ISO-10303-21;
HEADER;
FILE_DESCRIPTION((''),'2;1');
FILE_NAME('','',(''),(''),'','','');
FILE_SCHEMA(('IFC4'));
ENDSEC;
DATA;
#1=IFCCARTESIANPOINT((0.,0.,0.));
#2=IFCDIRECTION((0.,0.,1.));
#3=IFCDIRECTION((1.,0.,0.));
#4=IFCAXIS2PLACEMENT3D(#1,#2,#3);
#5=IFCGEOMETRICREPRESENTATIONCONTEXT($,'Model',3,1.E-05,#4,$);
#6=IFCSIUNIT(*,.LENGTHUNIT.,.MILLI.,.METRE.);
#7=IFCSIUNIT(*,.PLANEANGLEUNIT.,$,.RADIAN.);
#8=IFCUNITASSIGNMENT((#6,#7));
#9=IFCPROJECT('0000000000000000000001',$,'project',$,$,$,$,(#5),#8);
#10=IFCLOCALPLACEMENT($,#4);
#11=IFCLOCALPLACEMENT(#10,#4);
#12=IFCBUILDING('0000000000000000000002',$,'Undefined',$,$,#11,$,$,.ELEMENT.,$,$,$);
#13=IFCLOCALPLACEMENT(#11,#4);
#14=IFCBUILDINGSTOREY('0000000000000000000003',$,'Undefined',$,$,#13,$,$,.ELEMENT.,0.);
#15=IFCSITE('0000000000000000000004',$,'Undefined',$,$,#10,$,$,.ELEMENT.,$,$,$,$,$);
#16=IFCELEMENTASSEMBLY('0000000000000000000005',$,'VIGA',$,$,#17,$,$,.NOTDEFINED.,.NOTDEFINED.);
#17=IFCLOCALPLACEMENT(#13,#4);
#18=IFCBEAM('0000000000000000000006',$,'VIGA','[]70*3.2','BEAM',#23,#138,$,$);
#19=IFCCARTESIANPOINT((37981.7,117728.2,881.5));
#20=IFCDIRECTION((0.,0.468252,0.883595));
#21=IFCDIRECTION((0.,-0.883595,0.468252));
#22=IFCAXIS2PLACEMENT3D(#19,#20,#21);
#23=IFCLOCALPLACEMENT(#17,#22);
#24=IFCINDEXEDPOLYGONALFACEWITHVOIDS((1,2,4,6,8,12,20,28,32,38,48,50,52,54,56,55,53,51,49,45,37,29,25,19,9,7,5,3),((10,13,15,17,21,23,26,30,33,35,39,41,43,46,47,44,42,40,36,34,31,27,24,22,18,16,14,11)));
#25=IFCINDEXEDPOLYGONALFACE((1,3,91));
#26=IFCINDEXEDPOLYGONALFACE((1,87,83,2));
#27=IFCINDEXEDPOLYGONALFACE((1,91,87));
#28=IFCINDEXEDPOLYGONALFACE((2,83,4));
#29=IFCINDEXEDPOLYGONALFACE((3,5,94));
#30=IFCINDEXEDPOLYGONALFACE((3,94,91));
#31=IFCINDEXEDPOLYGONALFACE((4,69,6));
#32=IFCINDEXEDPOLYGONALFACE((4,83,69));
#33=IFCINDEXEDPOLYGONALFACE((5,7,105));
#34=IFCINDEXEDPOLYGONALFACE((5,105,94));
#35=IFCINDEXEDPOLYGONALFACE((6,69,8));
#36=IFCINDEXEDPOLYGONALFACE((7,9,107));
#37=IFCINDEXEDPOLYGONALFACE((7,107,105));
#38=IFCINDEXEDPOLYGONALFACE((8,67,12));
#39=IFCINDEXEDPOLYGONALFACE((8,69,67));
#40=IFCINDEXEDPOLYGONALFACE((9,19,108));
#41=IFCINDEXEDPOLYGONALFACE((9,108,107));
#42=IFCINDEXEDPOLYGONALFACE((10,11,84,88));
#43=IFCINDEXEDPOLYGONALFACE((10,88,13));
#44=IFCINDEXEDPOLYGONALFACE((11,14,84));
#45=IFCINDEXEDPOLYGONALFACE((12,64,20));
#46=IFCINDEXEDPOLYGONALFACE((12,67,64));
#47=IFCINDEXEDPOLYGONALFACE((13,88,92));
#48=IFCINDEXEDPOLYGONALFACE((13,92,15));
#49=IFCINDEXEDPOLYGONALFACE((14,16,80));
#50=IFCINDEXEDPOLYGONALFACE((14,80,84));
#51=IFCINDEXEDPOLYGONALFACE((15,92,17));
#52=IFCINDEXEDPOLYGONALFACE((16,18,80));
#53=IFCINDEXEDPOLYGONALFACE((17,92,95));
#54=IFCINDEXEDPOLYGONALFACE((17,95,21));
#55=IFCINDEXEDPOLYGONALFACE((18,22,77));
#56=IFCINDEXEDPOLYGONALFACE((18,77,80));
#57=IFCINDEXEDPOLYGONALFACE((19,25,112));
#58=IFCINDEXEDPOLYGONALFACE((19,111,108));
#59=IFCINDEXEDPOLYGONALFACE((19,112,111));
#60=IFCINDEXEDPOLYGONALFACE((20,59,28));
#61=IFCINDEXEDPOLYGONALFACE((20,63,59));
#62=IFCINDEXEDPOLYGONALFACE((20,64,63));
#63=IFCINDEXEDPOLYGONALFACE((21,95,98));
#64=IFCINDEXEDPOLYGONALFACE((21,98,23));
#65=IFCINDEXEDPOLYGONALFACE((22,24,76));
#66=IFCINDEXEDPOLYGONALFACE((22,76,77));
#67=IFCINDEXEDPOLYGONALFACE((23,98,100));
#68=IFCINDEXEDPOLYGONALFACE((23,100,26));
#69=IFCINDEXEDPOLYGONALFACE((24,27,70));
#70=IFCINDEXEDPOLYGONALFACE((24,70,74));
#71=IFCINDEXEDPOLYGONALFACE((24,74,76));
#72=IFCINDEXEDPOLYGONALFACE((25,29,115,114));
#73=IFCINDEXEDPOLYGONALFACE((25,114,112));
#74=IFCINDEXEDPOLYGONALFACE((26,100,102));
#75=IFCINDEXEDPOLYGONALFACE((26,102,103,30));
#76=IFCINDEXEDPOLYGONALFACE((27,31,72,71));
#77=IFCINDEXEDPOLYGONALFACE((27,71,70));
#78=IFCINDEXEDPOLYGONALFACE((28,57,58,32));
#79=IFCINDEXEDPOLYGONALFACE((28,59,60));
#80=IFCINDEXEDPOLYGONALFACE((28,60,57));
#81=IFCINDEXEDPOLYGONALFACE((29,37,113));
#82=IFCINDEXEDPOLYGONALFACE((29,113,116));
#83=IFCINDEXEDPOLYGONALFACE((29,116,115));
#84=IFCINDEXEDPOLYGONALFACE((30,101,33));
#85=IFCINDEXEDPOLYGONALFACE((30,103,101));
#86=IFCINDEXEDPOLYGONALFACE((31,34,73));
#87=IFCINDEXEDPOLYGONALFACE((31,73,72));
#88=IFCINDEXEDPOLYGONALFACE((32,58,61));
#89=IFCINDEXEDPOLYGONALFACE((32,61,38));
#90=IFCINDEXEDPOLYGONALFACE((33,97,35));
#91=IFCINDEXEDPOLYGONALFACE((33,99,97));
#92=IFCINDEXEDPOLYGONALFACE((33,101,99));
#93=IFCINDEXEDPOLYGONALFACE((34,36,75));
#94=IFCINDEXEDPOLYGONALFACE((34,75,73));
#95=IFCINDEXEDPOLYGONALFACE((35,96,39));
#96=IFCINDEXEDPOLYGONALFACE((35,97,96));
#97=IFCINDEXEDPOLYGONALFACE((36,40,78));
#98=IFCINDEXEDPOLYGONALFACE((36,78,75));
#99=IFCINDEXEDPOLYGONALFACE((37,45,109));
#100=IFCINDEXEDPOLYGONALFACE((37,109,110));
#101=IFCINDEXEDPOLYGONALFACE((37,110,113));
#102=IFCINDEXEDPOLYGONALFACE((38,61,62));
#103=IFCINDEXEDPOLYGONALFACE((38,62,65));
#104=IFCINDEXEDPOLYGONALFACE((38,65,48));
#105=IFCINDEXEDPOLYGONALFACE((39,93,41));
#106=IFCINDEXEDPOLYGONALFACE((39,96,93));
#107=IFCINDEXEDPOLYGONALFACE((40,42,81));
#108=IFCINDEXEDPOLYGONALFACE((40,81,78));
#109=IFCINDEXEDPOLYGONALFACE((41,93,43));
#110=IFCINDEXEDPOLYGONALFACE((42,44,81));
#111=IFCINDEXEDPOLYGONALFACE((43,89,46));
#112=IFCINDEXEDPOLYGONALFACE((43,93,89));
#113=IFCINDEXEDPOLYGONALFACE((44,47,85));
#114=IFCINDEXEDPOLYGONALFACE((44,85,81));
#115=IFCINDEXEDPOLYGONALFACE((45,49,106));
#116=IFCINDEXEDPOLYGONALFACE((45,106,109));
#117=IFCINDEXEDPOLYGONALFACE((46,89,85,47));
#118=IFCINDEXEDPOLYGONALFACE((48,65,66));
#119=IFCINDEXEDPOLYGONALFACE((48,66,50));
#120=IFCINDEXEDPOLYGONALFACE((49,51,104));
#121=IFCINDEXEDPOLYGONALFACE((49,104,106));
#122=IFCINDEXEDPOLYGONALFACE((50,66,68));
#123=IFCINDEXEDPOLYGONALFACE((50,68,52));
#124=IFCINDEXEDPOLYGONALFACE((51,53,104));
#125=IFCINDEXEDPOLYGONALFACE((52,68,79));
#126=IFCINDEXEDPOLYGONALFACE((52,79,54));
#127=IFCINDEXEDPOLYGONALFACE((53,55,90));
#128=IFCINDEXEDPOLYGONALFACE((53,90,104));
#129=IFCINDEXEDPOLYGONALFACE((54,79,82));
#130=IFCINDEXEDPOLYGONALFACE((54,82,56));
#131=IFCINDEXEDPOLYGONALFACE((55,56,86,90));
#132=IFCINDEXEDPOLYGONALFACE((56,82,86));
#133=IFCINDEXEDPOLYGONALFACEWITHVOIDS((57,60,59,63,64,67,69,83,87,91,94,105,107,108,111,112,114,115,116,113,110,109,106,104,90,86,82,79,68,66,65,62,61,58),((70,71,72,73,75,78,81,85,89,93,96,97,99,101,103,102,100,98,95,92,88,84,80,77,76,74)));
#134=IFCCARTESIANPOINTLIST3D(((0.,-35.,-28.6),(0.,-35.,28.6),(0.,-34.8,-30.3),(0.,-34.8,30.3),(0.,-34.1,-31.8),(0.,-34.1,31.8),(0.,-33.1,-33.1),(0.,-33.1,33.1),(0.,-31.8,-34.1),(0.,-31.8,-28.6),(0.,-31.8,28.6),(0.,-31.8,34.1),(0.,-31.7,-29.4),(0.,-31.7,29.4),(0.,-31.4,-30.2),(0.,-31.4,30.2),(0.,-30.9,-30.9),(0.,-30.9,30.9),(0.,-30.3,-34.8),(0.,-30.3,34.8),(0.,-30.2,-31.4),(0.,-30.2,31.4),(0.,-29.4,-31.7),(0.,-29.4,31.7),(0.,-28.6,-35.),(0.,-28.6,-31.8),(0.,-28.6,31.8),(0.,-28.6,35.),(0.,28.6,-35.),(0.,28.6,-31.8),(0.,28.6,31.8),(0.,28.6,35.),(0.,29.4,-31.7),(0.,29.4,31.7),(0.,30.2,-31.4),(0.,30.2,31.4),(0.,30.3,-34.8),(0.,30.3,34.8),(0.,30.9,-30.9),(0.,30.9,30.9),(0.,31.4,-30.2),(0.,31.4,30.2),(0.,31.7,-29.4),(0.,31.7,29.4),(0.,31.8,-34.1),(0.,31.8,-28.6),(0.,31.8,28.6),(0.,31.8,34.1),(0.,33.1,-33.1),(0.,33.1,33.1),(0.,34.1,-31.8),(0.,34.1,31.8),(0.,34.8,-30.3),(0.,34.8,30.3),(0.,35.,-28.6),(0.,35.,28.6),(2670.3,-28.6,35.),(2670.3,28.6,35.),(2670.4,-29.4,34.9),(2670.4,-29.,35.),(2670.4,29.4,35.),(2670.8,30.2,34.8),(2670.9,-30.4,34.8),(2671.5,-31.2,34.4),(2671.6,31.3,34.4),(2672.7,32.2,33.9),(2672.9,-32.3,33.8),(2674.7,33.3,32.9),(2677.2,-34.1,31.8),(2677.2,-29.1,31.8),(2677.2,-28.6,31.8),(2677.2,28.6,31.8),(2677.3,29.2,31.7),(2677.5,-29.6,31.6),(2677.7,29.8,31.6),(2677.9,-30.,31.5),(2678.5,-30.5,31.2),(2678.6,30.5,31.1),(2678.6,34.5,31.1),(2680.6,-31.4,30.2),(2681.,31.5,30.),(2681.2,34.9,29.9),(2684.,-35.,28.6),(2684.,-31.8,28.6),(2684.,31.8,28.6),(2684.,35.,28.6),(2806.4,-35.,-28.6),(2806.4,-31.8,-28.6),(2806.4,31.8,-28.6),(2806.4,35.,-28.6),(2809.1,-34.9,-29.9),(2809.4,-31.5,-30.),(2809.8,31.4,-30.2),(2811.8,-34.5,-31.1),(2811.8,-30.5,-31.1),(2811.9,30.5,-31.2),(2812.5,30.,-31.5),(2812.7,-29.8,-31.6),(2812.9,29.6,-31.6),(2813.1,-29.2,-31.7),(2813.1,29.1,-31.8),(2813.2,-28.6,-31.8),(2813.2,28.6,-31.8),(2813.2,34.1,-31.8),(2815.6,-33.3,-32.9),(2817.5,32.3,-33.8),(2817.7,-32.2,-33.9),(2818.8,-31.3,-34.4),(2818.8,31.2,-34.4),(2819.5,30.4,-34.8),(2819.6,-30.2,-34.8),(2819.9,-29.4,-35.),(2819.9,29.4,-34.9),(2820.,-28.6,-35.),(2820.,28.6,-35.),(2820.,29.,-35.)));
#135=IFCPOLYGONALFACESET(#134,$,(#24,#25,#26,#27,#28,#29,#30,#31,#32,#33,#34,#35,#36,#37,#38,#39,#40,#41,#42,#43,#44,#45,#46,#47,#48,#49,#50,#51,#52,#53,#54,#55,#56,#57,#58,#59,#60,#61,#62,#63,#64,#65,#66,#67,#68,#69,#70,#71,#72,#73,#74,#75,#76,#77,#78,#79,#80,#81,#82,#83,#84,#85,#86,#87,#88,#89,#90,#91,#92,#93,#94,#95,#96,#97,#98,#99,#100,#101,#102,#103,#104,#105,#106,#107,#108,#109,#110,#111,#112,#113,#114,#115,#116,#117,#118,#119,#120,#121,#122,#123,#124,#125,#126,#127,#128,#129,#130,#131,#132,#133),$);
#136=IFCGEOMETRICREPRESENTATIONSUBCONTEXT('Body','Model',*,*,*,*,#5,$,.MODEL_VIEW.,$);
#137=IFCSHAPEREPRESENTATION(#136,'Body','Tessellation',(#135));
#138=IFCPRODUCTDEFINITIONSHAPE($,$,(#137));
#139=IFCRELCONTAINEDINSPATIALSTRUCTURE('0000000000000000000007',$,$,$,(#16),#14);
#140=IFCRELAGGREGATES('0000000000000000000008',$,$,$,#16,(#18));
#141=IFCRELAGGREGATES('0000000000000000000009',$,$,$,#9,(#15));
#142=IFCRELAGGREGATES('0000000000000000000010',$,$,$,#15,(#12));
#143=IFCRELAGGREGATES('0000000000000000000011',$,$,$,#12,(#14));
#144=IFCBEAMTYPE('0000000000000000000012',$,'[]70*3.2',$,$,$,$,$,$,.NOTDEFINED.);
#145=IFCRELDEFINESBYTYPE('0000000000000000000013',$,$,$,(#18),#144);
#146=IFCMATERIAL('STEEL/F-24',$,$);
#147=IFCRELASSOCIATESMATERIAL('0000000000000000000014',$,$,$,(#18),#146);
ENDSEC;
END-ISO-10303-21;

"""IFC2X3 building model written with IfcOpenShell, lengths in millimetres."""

from ifc_helpers import new_model, si_unit, frame, origin_with_axes, origin_2d_with_axis, place, context, subcontext, project, spatial, hollow_rectangle, extrude, clip, halfspace, material, type_object, element, aggregate, save


model = new_model("IFC2X3")

# Units and contexts
model_context = context("Model", 3, precision=1e-05, world=origin_with_axes())
body_context = subcontext(model_context, "Body", "Model", "MODEL_VIEW")
ifc_project = project(units=[si_unit("LENGTHUNIT", "METRE", prefix="MILLI"), si_unit("PLANEANGLEUNIT", "RADIAN")], contexts=[model_context])

# Site, building, storey
site_placement = place(None, origin_with_axes())
site = spatial("IfcSite", under=ifc_project, at=site_placement, Name="Undefined", CompositionType="ELEMENT")
building_placement = place(site_placement, origin_with_axes())
building = spatial("IfcBuilding", under=site, at=building_placement, Name="Undefined", CompositionType="ELEMENT")
storey_placement = place(building_placement, origin_with_axes())
storey = spatial("IfcBuildingStorey", under=building, at=storey_placement, Name="Undefined", CompositionType="ELEMENT", Elevation=0.0)

# Element assembly, beam
assembly_1_placement = place(storey_placement, origin_with_axes())
assembly_1 = element("IfcElementAssembly", 1, at=assembly_1_placement, inside=storey, Name="VIGA", AssemblyPlace="NOTDEFINED", PredefinedType="NOTDEFINED")
ifc_material_1 = material(Name="STEEL/F-24")
beam_type = type_object("IfcBeamType", Name="[]70*3.2", PredefinedType="NOTDEFINED")
beam_placement = place(assembly_1_placement, frame((37981.7, 117728.2, 881.5), z_axis=(0.0, 0.468252, 0.883595), x_axis=(0.0, -0.883595, 0.468252)))
beam = element("IfcBeam", 2, at=beam_placement, type_object=beam_type, material=ifc_material_1, Name="VIGA", Description="[]70*3.2", ObjectType="BEAM", context=body_context, shape_type="Clipping", body=[
    clip(extrude(hollow_rectangle(XDim=70.0, YDim=70.0, WallThickness=3.2, InnerFilletRadius=3.2, OuterFilletRadius=6.4, at=origin_2d_with_axis()), frame((2850.0, 0.0, 0.0), z_axis=(-1.0, 0.0, 0.0), x_axis=(0.0, -1.0, 0.0)), (0.0, 0.0, 1.0), 2850.0), halfspace(frame((2745.2, 0.0, 0.0), z_axis=(-0.423531, 0.0, -0.905881), x_axis=(0.905881, 0.0, -0.423531)), True)),
])

aggregate(assembly_1, [beam])

save(model, "model.ifc")
